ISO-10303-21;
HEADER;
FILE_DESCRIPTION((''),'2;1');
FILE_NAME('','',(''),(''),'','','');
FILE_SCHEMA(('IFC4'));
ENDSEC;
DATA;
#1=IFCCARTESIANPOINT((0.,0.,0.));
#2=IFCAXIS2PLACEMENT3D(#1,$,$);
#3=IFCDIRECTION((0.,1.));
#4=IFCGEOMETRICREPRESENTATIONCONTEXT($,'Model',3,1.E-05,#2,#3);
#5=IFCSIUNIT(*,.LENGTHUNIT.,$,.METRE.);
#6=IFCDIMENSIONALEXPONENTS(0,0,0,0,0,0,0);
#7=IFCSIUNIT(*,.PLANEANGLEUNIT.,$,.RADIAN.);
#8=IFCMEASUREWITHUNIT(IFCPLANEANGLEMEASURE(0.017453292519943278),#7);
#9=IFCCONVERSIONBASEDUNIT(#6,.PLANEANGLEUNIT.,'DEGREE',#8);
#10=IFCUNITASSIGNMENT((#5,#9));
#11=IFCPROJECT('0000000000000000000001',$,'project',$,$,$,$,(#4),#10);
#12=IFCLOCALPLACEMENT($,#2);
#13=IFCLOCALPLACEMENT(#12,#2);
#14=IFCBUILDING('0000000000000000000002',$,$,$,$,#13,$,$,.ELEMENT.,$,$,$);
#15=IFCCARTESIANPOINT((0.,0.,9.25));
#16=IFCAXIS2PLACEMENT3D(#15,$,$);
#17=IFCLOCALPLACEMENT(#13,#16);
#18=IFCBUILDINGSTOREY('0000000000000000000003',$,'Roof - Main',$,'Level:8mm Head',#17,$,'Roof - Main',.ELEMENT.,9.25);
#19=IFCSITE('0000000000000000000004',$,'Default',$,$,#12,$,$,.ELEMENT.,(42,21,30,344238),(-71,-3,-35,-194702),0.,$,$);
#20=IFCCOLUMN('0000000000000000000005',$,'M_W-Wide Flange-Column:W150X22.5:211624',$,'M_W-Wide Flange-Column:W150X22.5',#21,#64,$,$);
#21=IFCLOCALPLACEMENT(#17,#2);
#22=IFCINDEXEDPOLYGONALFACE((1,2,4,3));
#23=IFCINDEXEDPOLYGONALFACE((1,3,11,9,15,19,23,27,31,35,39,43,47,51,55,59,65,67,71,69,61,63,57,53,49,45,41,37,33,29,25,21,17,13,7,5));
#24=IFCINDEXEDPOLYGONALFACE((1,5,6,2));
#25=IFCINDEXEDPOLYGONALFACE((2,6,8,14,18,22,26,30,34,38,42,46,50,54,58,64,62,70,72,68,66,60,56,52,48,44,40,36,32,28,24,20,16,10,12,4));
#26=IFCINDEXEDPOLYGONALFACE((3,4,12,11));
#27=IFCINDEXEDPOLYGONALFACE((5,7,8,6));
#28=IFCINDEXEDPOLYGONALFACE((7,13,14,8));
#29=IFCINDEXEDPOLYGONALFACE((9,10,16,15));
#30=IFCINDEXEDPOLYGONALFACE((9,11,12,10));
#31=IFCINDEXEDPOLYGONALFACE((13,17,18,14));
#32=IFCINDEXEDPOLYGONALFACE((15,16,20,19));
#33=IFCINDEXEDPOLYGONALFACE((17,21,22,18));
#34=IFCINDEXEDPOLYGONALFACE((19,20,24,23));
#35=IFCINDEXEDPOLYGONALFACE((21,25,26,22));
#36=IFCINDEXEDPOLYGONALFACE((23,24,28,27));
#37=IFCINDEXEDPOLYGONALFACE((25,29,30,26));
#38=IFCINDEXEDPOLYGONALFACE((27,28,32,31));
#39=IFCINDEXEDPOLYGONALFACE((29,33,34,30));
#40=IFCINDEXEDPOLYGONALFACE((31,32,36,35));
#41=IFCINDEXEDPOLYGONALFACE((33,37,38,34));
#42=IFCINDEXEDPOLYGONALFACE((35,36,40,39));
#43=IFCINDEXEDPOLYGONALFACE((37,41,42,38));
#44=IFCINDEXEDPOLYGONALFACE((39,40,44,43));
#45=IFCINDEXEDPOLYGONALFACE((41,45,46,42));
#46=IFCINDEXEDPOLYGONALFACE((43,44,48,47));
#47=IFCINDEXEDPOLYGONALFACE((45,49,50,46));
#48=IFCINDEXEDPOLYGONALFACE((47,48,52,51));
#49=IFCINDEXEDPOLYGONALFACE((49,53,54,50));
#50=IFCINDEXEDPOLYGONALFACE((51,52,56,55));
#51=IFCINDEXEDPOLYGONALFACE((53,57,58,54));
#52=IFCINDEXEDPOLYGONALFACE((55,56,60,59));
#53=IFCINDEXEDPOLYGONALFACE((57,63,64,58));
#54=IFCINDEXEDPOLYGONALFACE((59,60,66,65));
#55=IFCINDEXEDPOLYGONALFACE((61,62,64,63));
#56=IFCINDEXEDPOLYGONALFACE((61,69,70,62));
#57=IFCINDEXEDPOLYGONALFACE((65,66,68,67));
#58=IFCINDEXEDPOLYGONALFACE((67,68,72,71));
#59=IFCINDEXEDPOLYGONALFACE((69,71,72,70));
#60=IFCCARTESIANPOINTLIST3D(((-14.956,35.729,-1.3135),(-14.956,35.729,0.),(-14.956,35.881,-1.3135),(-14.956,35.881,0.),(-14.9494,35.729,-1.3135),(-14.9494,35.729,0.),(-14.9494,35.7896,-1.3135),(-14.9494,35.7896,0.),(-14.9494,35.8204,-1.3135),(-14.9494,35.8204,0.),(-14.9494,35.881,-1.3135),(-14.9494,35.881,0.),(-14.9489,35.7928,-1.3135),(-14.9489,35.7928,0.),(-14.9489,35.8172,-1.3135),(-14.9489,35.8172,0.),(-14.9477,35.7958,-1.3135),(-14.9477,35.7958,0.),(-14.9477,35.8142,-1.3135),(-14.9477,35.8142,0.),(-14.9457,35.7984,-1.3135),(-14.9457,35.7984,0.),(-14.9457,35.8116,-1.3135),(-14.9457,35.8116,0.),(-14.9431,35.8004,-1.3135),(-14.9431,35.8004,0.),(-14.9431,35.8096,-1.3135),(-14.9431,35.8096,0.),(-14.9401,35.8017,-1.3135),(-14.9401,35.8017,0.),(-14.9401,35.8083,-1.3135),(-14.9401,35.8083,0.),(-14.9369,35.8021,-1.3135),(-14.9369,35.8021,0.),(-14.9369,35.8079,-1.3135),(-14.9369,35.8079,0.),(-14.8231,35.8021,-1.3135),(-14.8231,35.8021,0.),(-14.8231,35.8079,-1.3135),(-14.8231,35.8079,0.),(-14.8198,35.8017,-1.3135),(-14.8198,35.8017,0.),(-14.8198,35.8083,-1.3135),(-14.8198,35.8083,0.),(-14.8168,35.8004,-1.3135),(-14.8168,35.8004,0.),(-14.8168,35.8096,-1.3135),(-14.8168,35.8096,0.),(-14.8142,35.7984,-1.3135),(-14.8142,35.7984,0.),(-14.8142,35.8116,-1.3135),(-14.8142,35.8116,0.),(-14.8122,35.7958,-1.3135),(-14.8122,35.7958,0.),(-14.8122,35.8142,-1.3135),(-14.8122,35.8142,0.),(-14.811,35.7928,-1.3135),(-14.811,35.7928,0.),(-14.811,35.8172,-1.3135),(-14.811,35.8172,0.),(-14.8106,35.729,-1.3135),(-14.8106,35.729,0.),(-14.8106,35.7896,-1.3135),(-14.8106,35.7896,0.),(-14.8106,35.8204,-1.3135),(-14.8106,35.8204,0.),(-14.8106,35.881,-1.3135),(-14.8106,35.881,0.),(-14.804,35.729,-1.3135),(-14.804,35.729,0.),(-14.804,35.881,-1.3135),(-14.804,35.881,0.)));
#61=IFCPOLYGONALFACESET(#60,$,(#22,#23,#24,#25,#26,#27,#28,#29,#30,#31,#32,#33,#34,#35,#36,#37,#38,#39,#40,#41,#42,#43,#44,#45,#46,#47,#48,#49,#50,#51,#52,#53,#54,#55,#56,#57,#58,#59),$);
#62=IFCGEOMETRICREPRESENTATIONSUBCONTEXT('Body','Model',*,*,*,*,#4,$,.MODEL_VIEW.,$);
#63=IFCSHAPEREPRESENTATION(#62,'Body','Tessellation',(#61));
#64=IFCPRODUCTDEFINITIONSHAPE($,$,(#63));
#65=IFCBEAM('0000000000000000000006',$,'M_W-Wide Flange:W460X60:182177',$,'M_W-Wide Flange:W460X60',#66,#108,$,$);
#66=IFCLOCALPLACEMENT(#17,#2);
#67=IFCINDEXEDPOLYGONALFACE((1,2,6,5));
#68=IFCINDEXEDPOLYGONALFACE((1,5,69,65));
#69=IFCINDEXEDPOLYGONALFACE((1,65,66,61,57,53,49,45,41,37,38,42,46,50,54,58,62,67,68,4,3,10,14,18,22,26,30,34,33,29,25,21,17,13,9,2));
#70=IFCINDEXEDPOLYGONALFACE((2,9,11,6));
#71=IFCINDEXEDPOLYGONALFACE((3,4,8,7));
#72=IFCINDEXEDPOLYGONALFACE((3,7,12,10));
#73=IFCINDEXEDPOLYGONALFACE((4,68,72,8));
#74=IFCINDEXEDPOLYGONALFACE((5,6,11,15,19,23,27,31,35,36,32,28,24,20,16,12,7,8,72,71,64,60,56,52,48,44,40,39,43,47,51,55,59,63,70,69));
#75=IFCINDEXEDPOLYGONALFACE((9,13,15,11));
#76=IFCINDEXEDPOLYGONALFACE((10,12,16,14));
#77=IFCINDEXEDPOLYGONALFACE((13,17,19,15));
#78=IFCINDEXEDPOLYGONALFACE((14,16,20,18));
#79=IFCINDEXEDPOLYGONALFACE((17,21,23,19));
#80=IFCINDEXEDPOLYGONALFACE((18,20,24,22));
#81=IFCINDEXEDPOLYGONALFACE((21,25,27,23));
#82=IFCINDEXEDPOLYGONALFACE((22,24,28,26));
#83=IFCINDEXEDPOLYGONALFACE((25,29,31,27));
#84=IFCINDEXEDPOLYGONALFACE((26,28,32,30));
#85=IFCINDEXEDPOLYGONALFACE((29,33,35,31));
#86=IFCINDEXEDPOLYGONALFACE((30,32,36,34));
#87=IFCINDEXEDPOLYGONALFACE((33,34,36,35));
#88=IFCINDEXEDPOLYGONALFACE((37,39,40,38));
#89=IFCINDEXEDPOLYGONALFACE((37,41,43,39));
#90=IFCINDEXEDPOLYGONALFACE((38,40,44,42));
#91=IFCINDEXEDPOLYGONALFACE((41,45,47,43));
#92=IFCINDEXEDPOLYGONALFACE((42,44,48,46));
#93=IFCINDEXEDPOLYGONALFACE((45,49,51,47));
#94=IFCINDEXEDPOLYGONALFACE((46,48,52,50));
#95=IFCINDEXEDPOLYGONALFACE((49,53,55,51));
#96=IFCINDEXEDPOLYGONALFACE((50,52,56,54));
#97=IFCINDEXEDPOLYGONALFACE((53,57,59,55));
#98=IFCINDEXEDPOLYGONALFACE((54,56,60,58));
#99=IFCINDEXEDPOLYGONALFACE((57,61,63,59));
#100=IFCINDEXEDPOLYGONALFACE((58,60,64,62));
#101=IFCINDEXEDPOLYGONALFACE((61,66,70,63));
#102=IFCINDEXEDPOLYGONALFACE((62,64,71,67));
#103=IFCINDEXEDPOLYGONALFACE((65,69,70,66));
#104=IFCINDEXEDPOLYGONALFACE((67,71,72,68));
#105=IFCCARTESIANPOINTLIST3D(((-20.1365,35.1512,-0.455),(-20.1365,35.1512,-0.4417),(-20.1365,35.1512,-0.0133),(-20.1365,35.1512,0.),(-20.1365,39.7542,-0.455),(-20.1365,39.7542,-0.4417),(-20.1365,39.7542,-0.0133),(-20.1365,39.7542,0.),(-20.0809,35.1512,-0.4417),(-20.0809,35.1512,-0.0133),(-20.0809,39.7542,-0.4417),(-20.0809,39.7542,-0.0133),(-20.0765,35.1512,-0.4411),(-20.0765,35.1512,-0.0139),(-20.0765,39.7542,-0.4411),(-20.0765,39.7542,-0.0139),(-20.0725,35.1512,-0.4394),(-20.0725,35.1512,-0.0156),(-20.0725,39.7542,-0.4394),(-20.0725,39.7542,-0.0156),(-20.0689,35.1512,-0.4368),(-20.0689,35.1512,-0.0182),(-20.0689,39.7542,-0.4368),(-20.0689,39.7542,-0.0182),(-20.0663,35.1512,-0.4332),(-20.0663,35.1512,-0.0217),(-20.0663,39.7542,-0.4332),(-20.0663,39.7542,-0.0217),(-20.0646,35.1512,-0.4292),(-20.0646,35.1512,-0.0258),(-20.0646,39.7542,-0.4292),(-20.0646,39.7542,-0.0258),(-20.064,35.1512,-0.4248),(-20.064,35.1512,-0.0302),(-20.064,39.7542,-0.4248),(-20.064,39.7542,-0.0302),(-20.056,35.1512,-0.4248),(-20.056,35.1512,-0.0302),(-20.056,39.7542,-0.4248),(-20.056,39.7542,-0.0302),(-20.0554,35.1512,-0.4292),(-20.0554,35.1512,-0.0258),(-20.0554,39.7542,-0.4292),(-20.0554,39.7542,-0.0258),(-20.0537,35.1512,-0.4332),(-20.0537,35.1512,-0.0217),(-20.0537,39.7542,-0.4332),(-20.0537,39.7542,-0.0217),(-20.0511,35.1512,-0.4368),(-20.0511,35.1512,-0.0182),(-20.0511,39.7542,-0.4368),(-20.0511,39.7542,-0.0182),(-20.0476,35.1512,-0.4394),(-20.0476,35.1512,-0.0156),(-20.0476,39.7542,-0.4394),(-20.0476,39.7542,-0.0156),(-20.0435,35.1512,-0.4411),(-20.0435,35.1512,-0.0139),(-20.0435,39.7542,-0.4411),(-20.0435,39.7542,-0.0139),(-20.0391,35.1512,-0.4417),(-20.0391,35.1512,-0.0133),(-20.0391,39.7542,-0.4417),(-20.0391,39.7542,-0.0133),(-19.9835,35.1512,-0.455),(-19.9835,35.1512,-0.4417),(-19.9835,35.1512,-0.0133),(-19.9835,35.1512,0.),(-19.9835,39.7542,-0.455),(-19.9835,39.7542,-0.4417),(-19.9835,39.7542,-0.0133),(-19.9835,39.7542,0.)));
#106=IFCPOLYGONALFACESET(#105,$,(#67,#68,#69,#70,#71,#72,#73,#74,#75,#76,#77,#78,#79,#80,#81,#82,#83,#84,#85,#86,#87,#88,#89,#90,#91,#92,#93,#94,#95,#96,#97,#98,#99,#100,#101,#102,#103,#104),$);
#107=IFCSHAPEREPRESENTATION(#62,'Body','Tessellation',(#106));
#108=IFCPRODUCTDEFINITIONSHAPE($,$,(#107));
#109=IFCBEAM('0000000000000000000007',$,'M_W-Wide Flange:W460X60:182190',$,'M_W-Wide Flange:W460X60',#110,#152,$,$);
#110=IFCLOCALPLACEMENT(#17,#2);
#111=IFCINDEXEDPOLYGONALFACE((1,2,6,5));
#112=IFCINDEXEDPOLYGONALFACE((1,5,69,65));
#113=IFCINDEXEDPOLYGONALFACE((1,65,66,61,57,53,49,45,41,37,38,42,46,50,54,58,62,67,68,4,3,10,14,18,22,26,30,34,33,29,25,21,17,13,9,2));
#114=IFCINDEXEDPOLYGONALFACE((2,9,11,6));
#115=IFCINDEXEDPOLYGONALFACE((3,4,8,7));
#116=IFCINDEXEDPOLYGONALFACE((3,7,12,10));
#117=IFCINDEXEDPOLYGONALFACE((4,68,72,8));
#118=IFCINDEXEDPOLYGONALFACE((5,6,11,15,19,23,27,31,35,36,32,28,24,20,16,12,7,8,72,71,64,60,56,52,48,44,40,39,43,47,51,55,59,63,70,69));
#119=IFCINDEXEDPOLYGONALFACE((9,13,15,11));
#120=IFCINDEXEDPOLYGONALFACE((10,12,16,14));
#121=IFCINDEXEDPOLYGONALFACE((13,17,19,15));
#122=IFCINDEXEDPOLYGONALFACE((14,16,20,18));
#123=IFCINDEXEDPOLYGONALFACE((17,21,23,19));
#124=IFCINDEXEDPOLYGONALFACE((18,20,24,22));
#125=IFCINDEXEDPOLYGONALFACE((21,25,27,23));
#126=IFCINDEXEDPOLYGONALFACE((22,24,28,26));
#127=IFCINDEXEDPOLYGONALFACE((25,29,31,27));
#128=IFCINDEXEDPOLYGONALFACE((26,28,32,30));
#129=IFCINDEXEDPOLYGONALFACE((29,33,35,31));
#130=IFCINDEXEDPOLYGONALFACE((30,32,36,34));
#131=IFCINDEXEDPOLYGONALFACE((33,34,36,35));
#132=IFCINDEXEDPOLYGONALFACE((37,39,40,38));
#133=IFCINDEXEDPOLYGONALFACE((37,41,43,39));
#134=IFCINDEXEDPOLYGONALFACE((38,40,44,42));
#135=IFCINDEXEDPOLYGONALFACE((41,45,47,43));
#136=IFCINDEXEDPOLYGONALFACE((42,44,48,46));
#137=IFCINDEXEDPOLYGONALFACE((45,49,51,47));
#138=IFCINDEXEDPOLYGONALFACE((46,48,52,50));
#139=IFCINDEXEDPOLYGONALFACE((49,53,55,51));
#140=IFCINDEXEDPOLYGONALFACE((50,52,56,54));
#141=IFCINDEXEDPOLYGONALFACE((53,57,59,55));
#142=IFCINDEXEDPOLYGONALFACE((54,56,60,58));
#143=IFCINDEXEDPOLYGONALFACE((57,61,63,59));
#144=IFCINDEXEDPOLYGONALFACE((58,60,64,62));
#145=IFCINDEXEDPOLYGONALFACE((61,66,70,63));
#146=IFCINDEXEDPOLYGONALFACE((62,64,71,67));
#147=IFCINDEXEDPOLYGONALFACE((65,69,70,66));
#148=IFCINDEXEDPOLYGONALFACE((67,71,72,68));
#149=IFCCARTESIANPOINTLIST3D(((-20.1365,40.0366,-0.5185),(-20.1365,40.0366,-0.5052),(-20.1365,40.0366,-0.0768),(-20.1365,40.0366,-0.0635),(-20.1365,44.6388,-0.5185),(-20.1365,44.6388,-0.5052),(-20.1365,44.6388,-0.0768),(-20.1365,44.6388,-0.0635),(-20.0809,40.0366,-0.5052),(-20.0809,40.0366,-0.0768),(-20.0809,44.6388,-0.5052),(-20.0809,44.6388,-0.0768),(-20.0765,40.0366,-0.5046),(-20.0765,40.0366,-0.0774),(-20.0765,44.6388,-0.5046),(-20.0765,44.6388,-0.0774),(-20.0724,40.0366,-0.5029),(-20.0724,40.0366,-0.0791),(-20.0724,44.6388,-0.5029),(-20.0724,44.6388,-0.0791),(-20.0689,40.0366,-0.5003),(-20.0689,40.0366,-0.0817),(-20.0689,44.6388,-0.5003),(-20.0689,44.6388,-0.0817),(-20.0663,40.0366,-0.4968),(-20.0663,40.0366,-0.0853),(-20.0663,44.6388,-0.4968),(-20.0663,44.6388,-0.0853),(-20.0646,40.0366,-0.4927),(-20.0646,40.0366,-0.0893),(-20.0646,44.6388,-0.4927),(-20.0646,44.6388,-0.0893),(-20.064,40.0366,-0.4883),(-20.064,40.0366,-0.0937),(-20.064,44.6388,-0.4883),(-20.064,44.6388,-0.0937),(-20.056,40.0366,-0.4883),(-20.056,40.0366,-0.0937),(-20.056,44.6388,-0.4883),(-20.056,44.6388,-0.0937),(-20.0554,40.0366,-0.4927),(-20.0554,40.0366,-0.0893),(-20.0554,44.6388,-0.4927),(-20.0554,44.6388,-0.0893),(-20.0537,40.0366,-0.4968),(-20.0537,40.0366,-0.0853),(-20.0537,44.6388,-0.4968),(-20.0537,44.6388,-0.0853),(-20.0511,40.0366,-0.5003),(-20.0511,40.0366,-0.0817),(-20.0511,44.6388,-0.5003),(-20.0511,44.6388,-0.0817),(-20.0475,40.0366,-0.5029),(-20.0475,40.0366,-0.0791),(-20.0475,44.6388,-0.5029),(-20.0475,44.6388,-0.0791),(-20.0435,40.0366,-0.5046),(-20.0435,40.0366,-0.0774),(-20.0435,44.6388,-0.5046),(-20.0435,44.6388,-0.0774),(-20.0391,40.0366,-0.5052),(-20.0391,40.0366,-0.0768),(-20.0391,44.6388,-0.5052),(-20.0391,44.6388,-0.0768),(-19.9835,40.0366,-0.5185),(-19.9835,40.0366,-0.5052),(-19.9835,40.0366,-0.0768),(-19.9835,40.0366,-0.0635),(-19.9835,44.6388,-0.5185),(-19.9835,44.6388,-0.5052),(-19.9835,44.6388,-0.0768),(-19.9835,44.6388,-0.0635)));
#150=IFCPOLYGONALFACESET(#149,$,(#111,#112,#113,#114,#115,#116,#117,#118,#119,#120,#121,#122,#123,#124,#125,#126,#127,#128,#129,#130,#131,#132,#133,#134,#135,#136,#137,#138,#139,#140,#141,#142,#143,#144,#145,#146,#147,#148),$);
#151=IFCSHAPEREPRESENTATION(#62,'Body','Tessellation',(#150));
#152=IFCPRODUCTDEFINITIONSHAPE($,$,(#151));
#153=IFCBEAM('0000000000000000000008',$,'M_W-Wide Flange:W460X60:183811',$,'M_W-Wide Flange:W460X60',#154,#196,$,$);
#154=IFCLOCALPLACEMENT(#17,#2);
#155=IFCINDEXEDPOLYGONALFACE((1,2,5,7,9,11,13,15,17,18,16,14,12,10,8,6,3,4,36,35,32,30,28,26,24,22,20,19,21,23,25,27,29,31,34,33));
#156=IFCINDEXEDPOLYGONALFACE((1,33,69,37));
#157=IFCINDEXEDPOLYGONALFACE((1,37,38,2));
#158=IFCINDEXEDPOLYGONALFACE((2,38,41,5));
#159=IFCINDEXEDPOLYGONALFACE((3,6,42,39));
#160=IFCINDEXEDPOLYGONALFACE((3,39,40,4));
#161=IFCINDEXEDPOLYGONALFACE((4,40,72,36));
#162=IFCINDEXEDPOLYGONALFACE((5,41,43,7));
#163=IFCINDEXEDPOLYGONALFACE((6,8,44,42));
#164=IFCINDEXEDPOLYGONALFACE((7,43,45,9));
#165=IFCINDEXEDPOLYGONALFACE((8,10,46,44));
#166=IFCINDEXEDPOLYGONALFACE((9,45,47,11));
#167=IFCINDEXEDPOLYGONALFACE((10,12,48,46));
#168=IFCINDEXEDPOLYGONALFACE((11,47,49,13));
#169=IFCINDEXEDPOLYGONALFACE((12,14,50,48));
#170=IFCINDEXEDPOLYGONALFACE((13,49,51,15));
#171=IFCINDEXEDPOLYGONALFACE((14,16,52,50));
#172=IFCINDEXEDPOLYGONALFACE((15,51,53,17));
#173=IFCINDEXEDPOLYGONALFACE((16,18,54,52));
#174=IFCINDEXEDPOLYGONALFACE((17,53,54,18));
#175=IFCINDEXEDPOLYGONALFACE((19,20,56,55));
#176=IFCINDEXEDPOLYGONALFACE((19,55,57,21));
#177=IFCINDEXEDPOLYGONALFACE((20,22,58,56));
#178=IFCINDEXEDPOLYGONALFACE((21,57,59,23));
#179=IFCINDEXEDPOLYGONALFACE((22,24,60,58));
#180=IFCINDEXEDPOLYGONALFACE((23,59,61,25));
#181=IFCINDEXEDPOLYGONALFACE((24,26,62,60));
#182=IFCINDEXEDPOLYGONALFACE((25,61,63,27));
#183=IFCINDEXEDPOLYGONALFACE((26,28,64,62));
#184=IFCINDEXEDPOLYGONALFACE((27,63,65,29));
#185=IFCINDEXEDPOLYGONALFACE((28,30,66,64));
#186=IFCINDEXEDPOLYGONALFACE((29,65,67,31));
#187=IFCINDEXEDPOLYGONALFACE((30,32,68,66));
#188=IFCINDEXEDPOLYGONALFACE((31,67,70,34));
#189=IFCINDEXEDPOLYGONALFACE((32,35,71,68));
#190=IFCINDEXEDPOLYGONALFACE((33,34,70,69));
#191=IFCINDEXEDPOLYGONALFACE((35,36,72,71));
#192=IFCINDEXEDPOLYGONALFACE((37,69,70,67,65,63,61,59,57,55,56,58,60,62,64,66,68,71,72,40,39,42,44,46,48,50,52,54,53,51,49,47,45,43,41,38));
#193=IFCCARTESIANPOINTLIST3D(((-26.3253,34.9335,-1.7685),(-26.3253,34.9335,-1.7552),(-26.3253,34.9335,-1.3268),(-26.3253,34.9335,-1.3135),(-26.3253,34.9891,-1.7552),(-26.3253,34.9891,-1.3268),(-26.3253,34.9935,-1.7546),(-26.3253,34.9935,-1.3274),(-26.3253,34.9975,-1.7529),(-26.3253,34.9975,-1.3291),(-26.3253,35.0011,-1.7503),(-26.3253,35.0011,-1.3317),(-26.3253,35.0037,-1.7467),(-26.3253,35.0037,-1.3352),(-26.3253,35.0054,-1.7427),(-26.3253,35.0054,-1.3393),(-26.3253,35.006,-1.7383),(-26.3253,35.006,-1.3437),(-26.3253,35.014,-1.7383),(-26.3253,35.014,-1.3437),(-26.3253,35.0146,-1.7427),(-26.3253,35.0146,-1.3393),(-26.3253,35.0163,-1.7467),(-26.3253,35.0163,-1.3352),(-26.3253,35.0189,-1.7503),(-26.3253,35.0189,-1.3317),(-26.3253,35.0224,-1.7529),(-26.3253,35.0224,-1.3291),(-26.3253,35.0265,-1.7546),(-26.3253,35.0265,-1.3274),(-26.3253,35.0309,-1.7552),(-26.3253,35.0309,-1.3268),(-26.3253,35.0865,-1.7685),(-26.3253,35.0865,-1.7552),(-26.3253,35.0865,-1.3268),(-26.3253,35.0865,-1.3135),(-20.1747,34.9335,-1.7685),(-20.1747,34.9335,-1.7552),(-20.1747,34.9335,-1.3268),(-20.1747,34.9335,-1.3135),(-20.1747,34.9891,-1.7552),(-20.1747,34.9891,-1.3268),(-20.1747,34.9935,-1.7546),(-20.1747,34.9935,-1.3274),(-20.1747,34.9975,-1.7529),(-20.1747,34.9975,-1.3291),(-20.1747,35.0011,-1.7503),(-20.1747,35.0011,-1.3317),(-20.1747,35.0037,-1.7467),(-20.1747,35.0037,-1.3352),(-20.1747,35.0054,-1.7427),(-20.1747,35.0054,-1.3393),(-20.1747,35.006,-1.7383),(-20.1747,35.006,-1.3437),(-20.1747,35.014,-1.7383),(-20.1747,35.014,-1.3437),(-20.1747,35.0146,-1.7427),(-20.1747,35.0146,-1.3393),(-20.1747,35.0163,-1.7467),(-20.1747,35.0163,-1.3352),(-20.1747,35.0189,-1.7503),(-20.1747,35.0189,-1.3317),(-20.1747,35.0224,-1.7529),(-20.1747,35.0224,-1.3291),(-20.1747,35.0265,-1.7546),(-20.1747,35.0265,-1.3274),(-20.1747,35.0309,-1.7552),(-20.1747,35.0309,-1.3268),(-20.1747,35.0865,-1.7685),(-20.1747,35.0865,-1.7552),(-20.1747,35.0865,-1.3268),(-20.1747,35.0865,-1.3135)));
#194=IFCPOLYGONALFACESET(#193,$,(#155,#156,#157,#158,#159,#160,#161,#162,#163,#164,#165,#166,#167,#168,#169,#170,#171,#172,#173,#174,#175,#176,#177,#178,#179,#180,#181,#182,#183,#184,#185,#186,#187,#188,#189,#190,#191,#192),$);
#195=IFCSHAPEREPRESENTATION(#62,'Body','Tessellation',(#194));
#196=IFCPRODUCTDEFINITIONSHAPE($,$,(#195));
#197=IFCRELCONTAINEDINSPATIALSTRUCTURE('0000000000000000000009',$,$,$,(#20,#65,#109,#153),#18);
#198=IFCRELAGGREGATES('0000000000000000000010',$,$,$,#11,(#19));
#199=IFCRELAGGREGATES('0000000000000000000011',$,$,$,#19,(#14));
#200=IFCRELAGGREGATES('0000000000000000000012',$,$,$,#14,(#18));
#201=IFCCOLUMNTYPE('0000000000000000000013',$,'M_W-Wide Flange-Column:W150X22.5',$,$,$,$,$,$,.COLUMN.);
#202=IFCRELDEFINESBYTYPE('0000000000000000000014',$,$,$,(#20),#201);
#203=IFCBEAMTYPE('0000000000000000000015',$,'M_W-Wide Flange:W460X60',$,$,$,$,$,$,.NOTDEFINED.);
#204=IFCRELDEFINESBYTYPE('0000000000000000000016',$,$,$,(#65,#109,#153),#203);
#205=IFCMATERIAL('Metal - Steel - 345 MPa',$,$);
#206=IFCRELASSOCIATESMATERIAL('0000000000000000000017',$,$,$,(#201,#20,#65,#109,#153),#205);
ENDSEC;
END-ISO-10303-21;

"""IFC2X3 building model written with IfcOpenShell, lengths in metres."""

from ifc_helpers import new_model, entity, si_unit, converted_unit, direction, frame, frame_2d, origin, place, context, subcontext, project, spatial, i_section, extrude, source, transform, mapped, material, type_object, type_shapes, element, save


model = new_model("IFC2X3")

# Units and contexts
model_context = context("Model", 3, precision=1e-05, world=origin(), true_north=direction((0.0, 1.0)))
body_context = subcontext(model_context, "Body", "Model", "MODEL_VIEW")
ifc_project = project(units=[si_unit("LENGTHUNIT", "METRE"), converted_unit("PLANEANGLEUNIT", "DEGREE", entity("IfcPlaneAngleMeasure", 0.017453292519943278), si_unit("PLANEANGLEUNIT", "RADIAN"), dimensions=[0, 0, 0, 0, 0, 0, 0])], contexts=[model_context])

# Site, building, storey
site_placement = place(None, origin())
site = spatial("IfcSite", under=ifc_project, at=site_placement, Name="Default", CompositionType="ELEMENT", RefLatitude=(42, 21, 30, 344238), RefLongitude=(-71, -3, -35, -194702), RefElevation=0.0)
building_placement = place(site_placement, origin())
building = spatial("IfcBuilding", under=site, at=building_placement, CompositionType="ELEMENT")
storey_placement = place(building_placement, frame((0.0, 0.0, 9.25)))
storey = spatial("IfcBuildingStorey", under=building, at=storey_placement, Name="Roof - Main", ObjectType="Level:8mm Head", LongName="Roof - Main", CompositionType="ELEMENT", Elevation=9.25)

# Column
ifc_material_1 = material(Name="Metal - Steel - 345 MPa")
column_type_1 = type_object("IfcColumnType", Name="M_W-Wide Flange-Column:W150X22.5", PredefinedType="COLUMN", material=ifc_material_1)
shared_shape_1 = source(origin(), body_context, "Body", "SweptSolid", [
    extrude(i_section(OverallWidth=0.152, OverallDepth=0.152, WebThickness=0.0058, FlangeThickness=0.0066, FilletRadius=0.0125, at=frame_2d((0.0, 0.0), x_axis=(1.0, 0.0))), frame((0.0, 0.0, 7.9365), z_axis=(0.0, 0.0, 1.0), x_axis=(-1.0, 0.0, 0.0)), (0.0, 0.0, 1.0), 1.3135),
])
type_shapes(column_type_1, [shared_shape_1])
column_1_placement = place(storey_placement, frame((-14.88, 35.805, -9.25), z_axis=(0.0, 0.0, 1.0), x_axis=(0.0, 1.0, 0.0)))
element("IfcColumn", 1, at=column_1_placement, inside=storey, type_object=column_type_1, material=ifc_material_1, Name="M_W-Wide Flange-Column:W150X22.5:211624", ObjectType="M_W-Wide Flange-Column:W150X22.5", context=body_context, shape_type="MappedRepresentation", body=[
    mapped(shared_shape_1, transform((0.0, 0.0, 0.0), scale=1.0)),
])

# Beams
beam_type_1 = type_object("IfcBeamType", Name="M_W-Wide Flange:W460X60", PredefinedType="NOTDEFINED")
beam_1_placement = place(storey_placement, frame((-20.06, 35.01, 0.0), z_axis=(0.0, 0.0, 1.0), x_axis=(0.0, 1.0, 0.0)))
element("IfcBeam", 2, at=beam_1_placement, inside=storey, type_object=beam_type_1, material=ifc_material_1, Name="M_W-Wide Flange:W460X60:182177", ObjectType="M_W-Wide Flange:W460X60", context=body_context, shape_type="SweptSolid", body=[
    extrude(i_section(OverallWidth=0.153, OverallDepth=0.455, WebThickness=0.008, FlangeThickness=0.0133, FilletRadius=0.0169, at=frame_2d((0.0, 0.0), x_axis=(0.0, 1.0))), frame((0.1412, 0.0, -0.2275), z_axis=(1.0, 0.0, 0.0), x_axis=(0.0, 0.0, -1.0)), (0.0, 0.0, 1.0), 4.603),
])
beam_2_placement = place(storey_placement, frame((-20.06, 39.8954, -0.0635), z_axis=(0.0, 0.0, 1.0), x_axis=(0.0, 1.0, 0.0)))
element("IfcBeam", 3, at=beam_2_placement, inside=storey, type_object=beam_type_1, material=ifc_material_1, Name="M_W-Wide Flange:W460X60:182190", ObjectType="M_W-Wide Flange:W460X60", context=body_context, shape_type="SweptSolid", body=[
    extrude(i_section(OverallWidth=0.153, OverallDepth=0.455, WebThickness=0.008, FlangeThickness=0.0133, FilletRadius=0.0169, at=frame_2d((0.0, 0.0), x_axis=(0.0, 1.0))), frame((0.1412, 0.0, -0.2275), z_axis=(1.0, 0.0, 0.0), x_axis=(0.0, 0.0, -1.0)), (0.0, 0.0, 1.0), 4.6022),
])
beam_3_placement = place(storey_placement, frame((-20.06, 35.01, -1.3135), z_axis=(0.0, 0.0, 1.0), x_axis=(-1.0, 0.0, 0.0)))
element("IfcBeam", 4, at=beam_3_placement, inside=storey, type_object=beam_type_1, material=ifc_material_1, Name="M_W-Wide Flange:W460X60:183811", ObjectType="M_W-Wide Flange:W460X60", context=body_context, shape_type="SweptSolid", body=[
    extrude(i_section(OverallWidth=0.153, OverallDepth=0.455, WebThickness=0.008, FlangeThickness=0.0133, FilletRadius=0.0169, at=frame_2d((0.0, 0.0), x_axis=(0.0, 1.0))), frame((0.1147, 0.0, -0.2275), z_axis=(1.0, 0.0, 0.0), x_axis=(0.0, 0.0, -1.0)), (0.0, 0.0, 1.0), 6.1506),
])

save(model, "model.ifc")
